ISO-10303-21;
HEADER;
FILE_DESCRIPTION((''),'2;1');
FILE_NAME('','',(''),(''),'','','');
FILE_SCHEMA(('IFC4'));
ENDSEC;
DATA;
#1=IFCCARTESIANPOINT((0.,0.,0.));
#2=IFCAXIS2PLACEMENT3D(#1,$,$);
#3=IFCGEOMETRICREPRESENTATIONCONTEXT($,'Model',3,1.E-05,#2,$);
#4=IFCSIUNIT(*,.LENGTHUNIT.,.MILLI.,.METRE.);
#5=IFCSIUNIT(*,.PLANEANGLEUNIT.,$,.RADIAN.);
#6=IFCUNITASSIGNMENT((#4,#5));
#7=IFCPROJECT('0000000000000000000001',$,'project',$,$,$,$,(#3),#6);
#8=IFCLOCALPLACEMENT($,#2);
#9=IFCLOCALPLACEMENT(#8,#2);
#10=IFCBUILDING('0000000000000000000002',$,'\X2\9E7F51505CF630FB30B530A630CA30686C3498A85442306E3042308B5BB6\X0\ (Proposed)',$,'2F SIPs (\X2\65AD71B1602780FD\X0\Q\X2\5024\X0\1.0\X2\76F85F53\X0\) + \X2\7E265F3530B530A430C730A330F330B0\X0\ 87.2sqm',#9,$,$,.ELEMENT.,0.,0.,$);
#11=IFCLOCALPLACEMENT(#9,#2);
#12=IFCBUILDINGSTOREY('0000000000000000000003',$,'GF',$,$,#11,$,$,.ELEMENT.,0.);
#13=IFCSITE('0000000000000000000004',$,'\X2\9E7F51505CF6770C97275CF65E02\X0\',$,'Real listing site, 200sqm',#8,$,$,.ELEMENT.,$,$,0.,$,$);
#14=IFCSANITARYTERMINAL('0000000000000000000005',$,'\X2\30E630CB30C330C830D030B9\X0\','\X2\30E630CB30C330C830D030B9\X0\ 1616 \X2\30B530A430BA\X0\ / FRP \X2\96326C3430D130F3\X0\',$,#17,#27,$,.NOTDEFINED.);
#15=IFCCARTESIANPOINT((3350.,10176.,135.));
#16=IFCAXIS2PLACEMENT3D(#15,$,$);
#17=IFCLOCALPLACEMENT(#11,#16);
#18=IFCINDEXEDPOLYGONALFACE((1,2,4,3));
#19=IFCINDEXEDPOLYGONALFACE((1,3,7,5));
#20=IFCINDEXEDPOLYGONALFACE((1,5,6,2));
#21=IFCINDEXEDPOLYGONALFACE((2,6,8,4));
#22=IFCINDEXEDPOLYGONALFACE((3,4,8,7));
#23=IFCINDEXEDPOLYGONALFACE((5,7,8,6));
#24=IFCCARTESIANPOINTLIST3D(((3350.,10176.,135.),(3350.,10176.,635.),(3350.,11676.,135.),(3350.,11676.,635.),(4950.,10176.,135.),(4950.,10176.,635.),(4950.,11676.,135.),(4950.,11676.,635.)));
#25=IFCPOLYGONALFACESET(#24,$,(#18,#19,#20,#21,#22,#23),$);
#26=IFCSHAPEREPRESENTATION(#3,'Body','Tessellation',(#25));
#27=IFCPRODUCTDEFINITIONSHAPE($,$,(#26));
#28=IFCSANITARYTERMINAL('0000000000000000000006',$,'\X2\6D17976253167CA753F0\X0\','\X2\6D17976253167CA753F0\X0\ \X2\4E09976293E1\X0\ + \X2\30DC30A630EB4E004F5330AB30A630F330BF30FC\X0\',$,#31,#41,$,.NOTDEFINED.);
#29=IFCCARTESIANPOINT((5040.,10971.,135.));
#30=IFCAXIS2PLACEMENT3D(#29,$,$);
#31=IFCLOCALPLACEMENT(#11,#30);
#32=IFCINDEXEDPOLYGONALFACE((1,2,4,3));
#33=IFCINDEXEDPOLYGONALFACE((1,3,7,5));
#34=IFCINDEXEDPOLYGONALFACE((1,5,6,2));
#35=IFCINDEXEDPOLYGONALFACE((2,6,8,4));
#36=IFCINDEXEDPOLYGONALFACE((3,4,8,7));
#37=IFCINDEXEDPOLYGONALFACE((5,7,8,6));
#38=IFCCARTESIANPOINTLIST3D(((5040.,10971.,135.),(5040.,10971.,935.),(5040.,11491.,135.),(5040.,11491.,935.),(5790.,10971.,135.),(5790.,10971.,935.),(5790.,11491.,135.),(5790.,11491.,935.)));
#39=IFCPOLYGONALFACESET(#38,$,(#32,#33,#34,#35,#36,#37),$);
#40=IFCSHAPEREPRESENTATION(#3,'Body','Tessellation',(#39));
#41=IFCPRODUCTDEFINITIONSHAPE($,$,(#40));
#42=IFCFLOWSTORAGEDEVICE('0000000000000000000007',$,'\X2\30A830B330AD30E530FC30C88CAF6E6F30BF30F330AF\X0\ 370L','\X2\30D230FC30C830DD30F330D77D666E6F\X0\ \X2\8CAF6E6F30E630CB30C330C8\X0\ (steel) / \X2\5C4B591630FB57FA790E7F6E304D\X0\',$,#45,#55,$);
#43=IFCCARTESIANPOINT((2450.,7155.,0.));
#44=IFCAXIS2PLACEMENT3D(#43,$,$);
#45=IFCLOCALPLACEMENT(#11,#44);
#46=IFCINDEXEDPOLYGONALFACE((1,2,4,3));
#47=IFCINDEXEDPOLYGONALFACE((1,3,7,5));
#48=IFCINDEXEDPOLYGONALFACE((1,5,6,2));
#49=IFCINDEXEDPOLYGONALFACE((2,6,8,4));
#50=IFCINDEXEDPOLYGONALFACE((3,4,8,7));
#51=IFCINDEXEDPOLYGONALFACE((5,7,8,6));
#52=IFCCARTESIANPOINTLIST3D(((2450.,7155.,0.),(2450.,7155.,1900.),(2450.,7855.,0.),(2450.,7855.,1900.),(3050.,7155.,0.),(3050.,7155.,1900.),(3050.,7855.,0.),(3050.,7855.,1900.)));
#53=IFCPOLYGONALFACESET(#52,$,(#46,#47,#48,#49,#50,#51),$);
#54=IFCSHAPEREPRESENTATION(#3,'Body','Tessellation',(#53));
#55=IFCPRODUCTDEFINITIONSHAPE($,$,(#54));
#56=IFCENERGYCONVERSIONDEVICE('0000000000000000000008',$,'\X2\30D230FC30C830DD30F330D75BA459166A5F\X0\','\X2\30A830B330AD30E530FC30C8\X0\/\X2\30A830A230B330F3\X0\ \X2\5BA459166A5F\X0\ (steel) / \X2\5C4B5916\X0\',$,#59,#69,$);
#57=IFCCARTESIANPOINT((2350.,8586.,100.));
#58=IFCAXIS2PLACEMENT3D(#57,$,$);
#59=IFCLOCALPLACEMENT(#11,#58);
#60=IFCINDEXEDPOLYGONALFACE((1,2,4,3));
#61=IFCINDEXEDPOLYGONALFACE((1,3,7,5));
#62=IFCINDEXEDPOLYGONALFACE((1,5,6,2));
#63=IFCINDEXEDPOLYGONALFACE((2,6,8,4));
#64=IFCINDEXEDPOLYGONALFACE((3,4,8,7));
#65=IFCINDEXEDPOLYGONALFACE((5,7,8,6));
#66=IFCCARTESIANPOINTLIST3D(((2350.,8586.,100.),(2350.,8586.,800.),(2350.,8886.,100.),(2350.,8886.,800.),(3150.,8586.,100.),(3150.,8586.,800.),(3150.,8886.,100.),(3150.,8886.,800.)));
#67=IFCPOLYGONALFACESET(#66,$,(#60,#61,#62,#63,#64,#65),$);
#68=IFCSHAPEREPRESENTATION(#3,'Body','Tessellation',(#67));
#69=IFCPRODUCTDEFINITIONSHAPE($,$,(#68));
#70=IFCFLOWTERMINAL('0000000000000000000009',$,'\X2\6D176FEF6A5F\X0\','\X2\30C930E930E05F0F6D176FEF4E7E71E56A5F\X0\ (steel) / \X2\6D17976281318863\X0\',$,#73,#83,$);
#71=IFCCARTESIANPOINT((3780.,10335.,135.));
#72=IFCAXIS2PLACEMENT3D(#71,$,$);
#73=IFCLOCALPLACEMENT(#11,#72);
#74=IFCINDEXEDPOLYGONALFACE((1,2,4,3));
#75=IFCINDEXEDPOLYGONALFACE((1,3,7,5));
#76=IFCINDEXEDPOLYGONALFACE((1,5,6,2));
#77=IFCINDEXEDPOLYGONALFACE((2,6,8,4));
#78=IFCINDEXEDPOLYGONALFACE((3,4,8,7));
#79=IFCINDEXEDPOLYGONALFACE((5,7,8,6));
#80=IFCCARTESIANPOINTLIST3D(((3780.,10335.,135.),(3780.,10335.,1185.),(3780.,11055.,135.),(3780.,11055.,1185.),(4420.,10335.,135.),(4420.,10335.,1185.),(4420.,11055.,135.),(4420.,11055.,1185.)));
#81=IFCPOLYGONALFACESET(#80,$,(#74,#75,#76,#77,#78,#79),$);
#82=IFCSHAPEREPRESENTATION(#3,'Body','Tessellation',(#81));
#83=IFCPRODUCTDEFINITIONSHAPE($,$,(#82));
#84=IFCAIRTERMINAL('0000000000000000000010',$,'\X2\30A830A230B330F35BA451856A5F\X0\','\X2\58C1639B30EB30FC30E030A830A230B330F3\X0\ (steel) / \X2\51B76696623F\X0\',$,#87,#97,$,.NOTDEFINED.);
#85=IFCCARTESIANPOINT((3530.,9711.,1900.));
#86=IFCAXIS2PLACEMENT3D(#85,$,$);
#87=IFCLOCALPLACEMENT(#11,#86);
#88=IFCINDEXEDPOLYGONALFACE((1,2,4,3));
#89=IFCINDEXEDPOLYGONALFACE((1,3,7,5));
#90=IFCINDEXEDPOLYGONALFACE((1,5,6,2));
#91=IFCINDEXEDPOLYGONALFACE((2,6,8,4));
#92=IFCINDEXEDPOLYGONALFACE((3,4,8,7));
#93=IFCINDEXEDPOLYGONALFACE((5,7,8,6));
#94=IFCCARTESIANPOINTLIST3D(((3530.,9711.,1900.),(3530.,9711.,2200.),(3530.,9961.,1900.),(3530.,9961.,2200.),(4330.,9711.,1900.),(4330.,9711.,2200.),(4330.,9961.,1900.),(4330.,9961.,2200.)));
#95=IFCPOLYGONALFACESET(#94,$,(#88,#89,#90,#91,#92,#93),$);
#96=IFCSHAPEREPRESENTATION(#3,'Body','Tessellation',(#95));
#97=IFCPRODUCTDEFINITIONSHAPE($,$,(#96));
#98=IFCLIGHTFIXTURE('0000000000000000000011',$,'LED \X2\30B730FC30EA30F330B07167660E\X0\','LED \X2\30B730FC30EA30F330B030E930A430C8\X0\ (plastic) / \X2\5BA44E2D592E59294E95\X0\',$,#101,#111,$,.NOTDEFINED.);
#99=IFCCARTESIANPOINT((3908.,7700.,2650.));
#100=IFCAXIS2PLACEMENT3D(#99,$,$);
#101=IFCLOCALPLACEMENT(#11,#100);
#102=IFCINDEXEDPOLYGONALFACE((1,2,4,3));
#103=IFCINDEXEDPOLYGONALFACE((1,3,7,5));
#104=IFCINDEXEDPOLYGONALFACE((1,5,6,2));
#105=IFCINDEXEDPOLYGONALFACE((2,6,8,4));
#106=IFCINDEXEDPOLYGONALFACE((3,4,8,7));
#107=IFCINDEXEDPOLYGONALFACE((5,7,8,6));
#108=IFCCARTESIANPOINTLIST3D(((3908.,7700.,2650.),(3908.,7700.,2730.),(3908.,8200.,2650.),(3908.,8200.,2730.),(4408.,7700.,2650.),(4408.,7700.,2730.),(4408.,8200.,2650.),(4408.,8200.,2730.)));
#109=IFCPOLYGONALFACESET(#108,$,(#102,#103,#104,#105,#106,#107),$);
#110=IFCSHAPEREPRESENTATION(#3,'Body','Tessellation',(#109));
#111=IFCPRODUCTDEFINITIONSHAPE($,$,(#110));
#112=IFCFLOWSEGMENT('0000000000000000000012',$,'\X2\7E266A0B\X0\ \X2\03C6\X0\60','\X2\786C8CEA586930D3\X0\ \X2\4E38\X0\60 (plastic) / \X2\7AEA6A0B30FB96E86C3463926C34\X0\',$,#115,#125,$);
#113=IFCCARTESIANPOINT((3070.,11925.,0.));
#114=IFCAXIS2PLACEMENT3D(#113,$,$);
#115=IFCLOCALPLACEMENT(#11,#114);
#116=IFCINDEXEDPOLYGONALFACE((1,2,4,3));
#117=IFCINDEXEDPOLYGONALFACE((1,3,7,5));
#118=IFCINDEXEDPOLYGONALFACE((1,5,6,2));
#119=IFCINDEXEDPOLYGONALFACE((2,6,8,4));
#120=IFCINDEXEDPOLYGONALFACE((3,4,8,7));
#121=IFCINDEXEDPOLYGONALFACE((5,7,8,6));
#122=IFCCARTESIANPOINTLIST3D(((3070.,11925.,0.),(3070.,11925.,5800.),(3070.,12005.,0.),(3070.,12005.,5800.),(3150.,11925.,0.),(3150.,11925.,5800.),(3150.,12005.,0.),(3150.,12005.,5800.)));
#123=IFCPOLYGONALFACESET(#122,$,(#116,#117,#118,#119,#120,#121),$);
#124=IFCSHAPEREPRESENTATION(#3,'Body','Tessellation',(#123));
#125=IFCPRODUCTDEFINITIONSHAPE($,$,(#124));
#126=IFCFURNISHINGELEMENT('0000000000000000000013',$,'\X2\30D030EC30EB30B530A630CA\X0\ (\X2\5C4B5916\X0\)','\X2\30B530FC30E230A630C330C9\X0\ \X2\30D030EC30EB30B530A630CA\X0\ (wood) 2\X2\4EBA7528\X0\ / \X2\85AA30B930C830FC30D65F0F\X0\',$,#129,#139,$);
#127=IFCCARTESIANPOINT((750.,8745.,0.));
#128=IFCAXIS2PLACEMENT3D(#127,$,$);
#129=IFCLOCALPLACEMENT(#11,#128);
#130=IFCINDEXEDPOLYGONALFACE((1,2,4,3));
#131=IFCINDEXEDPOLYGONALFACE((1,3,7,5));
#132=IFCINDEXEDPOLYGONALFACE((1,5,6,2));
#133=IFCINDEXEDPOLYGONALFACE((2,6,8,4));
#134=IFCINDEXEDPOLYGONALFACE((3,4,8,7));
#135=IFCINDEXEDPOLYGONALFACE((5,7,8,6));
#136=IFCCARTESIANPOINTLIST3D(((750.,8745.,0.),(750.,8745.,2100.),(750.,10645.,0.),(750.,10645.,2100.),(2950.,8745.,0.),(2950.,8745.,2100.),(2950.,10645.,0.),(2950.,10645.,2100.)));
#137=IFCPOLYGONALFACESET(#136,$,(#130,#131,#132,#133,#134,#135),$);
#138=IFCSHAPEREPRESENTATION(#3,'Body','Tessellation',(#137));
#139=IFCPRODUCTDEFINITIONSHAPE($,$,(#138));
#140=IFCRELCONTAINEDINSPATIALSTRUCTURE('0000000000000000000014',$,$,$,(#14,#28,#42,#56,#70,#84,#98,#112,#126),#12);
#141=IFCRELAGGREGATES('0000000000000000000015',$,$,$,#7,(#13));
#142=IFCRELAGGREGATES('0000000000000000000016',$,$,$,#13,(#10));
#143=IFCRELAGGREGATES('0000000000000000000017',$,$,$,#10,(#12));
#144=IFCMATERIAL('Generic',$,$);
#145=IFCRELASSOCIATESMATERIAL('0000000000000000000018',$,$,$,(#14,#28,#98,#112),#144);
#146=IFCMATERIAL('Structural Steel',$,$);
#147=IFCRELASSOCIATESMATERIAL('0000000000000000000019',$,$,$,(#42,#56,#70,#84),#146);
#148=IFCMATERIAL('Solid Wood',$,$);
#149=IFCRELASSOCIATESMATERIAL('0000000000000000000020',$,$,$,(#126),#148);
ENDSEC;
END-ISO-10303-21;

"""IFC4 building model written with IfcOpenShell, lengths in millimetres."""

from ifc_helpers import new_model, si_unit, frame, frame_2d, origin, place, context, project, spatial, rectangle, extrude, material, element, save


model = new_model("IFC4")

# Units and contexts
model_context = context("Model", 3, precision=1e-05, world=origin())
ifc_project = project(units=[si_unit("LENGTHUNIT", "METRE", prefix="MILLI"), si_unit("PLANEANGLEUNIT", "RADIAN")], contexts=[model_context])

# Site, building, storey
site_placement = place(None, origin())
site = spatial("IfcSite", under=ifc_project, at=site_placement, Name="鹿児島県霧島市", ObjectType="Real listing site, 200sqm", CompositionType="ELEMENT", RefElevation=0.0)
building_placement = place(site_placement, origin())
building = spatial("IfcBuilding", under=site, at=building_placement, Name="鹿児島・サウナと水風呂のある家 (Proposed)", ObjectType="2F SIPs (断熱性能Q値1.0相当) + 縦張サイディング 87.2sqm", CompositionType="ELEMENT", ElevationOfRefHeight=0.0, ElevationOfTerrain=0.0)
storey_placement = place(building_placement, origin())
storey = spatial("IfcBuildingStorey", under=building, at=storey_placement, Name="GF", CompositionType="ELEMENT", Elevation=0.0)

# Shared definitions
ifc_material_1 = material(Name="Solid Wood")

# Shared definitions
ifc_material_2 = material(Name="Generic")

# Sanitary terminals
sanitary_terminal_1_placement = place(storey_placement, frame((3350.0, 10176.0, 135.0)))
element("IfcSanitaryTerminal", 1, at=sanitary_terminal_1_placement, inside=storey, material=ifc_material_2, Name="ユニットバス", Description="ユニットバス 1616 サイズ / FRP 防水パン", PredefinedType="NOTDEFINED", context=model_context, shape_type="SweptSolid", body=[
    extrude(rectangle(XDim=1600.0, YDim=1500.0, at=frame_2d((800.0, 750.0))), frame((3350.0, 10176.0, 135.0)), (0.0, 0.0, 1.0), 500.0),
])
sanitary_terminal_2_placement = place(storey_placement, frame((5040.0, 10971.0, 135.0)))
element("IfcSanitaryTerminal", 2, at=sanitary_terminal_2_placement, inside=storey, material=ifc_material_2, Name="洗面化粧台", Description="洗面化粧台 三面鏡 + ボウル一体カウンター", PredefinedType="NOTDEFINED", context=model_context, shape_type="SweptSolid", body=[
    extrude(rectangle(XDim=750.0, YDim=520.0, at=frame_2d((375.0, 260.0))), frame((5040.0, 10971.0, 135.0)), (0.0, 0.0, 1.0), 800.0),
])

# Flow storage device
ifc_material_3 = material(Name="Structural Steel")
flow_storage_device_placement = place(storey_placement, frame((2450.0, 7155.0, 0.0)))
element("IfcFlowStorageDevice", 3, at=flow_storage_device_placement, inside=storey, material=ifc_material_3, Name="エコキュート貯湯タンク 370L", Description="ヒートポンプ給湯 貯湯ユニット (steel) / 屋外・基礎置き", context=model_context, shape_type="SweptSolid", body=[
    extrude(rectangle(XDim=600.0, YDim=700.0, at=frame_2d((300.0, 350.0))), frame((2450.0, 7155.0, 0.0)), (0.0, 0.0, 1.0), 1900.0),
])

# Energy conversion device
energy_conversion_device_placement = place(storey_placement, frame((2350.0, 8586.0, 100.0)))
element("IfcEnergyConversionDevice", 4, at=energy_conversion_device_placement, inside=storey, material=ifc_material_3, Name="ヒートポンプ室外機", Description="エコキュート/エアコン 室外機 (steel) / 屋外", context=model_context, shape_type="SweptSolid", body=[
    extrude(rectangle(XDim=800.0, YDim=300.0, at=frame_2d((400.0, 150.0))), frame((2350.0, 8586.0, 100.0)), (0.0, 0.0, 1.0), 700.0),
])

# Flow terminal
flow_terminal_placement = place(storey_placement, frame((3780.0, 10335.0, 135.0)))
element("IfcFlowTerminal", 5, at=flow_terminal_placement, inside=storey, material=ifc_material_3, Name="洗濯機", Description="ドラム式洗濯乾燥機 (steel) / 洗面脱衣", context=model_context, shape_type="SweptSolid", body=[
    extrude(rectangle(XDim=640.0, YDim=720.0, at=frame_2d((320.0, 360.0))), frame((3780.0, 10335.0, 135.0)), (0.0, 0.0, 1.0), 1050.0),
])

# Air terminal
air_terminal_placement = place(storey_placement, frame((3530.0, 9711.0, 1900.0)))
element("IfcAirTerminal", 6, at=air_terminal_placement, inside=storey, material=ifc_material_3, Name="エアコン室内機", Description="壁掛ルームエアコン (steel) / 冷暖房", PredefinedType="NOTDEFINED", context=model_context, shape_type="SweptSolid", body=[
    extrude(rectangle(XDim=800.0, YDim=250.0, at=frame_2d((400.0, 125.0))), frame((3530.0, 9711.0, 1900.0)), (0.0, 0.0, 1.0), 300.0),
])

# Light fixture
light_fixture_placement = place(storey_placement, frame((3908.0, 7700.0, 2650.0)))
element("IfcLightFixture", 7, at=light_fixture_placement, inside=storey, material=ifc_material_2, Name="LED シーリング照明", Description="LED シーリングライト (plastic) / 室中央天井", PredefinedType="NOTDEFINED", context=model_context, shape_type="SweptSolid", body=[
    extrude(rectangle(XDim=500.0, YDim=500.0, at=frame_2d((250.0, 250.0))), frame((3908.0, 7700.0, 2650.0)), (0.0, 0.0, 1.0), 80.0),
])

# Flow segment
flow_segment_placement = place(storey_placement, frame((3070.0, 11925.0, 0.0)))
element("IfcFlowSegment", 8, at=flow_segment_placement, inside=storey, material=ifc_material_2, Name="縦樋 φ60", Description="硬質塩ビ 丸60 (plastic) / 竪樋・雨水排水", context=model_context, shape_type="SweptSolid", body=[
    extrude(rectangle(XDim=80.0, YDim=80.0, at=frame_2d((40.0, 40.0))), frame((3070.0, 11925.0, 0.0)), (0.0, 0.0, 1.0), 5800.0),
])

# Furnishing element
furnishing_placement = place(storey_placement, frame((750.0, 8745.0, 0.0)))
element("IfcFurnishingElement", 9, at=furnishing_placement, inside=storey, material=ifc_material_1, Name="バレルサウナ (屋外)", Description="サーモウッド バレルサウナ (wood) 2人用 / 薪ストーブ式", context=model_context, shape_type="SweptSolid", body=[
    extrude(rectangle(XDim=2200.0, YDim=1900.0, at=frame_2d((1100.0, 950.0))), frame((750.0, 8745.0, 0.0)), (0.0, 0.0, 1.0), 2100.0),
])

save(model, "model.ifc")
